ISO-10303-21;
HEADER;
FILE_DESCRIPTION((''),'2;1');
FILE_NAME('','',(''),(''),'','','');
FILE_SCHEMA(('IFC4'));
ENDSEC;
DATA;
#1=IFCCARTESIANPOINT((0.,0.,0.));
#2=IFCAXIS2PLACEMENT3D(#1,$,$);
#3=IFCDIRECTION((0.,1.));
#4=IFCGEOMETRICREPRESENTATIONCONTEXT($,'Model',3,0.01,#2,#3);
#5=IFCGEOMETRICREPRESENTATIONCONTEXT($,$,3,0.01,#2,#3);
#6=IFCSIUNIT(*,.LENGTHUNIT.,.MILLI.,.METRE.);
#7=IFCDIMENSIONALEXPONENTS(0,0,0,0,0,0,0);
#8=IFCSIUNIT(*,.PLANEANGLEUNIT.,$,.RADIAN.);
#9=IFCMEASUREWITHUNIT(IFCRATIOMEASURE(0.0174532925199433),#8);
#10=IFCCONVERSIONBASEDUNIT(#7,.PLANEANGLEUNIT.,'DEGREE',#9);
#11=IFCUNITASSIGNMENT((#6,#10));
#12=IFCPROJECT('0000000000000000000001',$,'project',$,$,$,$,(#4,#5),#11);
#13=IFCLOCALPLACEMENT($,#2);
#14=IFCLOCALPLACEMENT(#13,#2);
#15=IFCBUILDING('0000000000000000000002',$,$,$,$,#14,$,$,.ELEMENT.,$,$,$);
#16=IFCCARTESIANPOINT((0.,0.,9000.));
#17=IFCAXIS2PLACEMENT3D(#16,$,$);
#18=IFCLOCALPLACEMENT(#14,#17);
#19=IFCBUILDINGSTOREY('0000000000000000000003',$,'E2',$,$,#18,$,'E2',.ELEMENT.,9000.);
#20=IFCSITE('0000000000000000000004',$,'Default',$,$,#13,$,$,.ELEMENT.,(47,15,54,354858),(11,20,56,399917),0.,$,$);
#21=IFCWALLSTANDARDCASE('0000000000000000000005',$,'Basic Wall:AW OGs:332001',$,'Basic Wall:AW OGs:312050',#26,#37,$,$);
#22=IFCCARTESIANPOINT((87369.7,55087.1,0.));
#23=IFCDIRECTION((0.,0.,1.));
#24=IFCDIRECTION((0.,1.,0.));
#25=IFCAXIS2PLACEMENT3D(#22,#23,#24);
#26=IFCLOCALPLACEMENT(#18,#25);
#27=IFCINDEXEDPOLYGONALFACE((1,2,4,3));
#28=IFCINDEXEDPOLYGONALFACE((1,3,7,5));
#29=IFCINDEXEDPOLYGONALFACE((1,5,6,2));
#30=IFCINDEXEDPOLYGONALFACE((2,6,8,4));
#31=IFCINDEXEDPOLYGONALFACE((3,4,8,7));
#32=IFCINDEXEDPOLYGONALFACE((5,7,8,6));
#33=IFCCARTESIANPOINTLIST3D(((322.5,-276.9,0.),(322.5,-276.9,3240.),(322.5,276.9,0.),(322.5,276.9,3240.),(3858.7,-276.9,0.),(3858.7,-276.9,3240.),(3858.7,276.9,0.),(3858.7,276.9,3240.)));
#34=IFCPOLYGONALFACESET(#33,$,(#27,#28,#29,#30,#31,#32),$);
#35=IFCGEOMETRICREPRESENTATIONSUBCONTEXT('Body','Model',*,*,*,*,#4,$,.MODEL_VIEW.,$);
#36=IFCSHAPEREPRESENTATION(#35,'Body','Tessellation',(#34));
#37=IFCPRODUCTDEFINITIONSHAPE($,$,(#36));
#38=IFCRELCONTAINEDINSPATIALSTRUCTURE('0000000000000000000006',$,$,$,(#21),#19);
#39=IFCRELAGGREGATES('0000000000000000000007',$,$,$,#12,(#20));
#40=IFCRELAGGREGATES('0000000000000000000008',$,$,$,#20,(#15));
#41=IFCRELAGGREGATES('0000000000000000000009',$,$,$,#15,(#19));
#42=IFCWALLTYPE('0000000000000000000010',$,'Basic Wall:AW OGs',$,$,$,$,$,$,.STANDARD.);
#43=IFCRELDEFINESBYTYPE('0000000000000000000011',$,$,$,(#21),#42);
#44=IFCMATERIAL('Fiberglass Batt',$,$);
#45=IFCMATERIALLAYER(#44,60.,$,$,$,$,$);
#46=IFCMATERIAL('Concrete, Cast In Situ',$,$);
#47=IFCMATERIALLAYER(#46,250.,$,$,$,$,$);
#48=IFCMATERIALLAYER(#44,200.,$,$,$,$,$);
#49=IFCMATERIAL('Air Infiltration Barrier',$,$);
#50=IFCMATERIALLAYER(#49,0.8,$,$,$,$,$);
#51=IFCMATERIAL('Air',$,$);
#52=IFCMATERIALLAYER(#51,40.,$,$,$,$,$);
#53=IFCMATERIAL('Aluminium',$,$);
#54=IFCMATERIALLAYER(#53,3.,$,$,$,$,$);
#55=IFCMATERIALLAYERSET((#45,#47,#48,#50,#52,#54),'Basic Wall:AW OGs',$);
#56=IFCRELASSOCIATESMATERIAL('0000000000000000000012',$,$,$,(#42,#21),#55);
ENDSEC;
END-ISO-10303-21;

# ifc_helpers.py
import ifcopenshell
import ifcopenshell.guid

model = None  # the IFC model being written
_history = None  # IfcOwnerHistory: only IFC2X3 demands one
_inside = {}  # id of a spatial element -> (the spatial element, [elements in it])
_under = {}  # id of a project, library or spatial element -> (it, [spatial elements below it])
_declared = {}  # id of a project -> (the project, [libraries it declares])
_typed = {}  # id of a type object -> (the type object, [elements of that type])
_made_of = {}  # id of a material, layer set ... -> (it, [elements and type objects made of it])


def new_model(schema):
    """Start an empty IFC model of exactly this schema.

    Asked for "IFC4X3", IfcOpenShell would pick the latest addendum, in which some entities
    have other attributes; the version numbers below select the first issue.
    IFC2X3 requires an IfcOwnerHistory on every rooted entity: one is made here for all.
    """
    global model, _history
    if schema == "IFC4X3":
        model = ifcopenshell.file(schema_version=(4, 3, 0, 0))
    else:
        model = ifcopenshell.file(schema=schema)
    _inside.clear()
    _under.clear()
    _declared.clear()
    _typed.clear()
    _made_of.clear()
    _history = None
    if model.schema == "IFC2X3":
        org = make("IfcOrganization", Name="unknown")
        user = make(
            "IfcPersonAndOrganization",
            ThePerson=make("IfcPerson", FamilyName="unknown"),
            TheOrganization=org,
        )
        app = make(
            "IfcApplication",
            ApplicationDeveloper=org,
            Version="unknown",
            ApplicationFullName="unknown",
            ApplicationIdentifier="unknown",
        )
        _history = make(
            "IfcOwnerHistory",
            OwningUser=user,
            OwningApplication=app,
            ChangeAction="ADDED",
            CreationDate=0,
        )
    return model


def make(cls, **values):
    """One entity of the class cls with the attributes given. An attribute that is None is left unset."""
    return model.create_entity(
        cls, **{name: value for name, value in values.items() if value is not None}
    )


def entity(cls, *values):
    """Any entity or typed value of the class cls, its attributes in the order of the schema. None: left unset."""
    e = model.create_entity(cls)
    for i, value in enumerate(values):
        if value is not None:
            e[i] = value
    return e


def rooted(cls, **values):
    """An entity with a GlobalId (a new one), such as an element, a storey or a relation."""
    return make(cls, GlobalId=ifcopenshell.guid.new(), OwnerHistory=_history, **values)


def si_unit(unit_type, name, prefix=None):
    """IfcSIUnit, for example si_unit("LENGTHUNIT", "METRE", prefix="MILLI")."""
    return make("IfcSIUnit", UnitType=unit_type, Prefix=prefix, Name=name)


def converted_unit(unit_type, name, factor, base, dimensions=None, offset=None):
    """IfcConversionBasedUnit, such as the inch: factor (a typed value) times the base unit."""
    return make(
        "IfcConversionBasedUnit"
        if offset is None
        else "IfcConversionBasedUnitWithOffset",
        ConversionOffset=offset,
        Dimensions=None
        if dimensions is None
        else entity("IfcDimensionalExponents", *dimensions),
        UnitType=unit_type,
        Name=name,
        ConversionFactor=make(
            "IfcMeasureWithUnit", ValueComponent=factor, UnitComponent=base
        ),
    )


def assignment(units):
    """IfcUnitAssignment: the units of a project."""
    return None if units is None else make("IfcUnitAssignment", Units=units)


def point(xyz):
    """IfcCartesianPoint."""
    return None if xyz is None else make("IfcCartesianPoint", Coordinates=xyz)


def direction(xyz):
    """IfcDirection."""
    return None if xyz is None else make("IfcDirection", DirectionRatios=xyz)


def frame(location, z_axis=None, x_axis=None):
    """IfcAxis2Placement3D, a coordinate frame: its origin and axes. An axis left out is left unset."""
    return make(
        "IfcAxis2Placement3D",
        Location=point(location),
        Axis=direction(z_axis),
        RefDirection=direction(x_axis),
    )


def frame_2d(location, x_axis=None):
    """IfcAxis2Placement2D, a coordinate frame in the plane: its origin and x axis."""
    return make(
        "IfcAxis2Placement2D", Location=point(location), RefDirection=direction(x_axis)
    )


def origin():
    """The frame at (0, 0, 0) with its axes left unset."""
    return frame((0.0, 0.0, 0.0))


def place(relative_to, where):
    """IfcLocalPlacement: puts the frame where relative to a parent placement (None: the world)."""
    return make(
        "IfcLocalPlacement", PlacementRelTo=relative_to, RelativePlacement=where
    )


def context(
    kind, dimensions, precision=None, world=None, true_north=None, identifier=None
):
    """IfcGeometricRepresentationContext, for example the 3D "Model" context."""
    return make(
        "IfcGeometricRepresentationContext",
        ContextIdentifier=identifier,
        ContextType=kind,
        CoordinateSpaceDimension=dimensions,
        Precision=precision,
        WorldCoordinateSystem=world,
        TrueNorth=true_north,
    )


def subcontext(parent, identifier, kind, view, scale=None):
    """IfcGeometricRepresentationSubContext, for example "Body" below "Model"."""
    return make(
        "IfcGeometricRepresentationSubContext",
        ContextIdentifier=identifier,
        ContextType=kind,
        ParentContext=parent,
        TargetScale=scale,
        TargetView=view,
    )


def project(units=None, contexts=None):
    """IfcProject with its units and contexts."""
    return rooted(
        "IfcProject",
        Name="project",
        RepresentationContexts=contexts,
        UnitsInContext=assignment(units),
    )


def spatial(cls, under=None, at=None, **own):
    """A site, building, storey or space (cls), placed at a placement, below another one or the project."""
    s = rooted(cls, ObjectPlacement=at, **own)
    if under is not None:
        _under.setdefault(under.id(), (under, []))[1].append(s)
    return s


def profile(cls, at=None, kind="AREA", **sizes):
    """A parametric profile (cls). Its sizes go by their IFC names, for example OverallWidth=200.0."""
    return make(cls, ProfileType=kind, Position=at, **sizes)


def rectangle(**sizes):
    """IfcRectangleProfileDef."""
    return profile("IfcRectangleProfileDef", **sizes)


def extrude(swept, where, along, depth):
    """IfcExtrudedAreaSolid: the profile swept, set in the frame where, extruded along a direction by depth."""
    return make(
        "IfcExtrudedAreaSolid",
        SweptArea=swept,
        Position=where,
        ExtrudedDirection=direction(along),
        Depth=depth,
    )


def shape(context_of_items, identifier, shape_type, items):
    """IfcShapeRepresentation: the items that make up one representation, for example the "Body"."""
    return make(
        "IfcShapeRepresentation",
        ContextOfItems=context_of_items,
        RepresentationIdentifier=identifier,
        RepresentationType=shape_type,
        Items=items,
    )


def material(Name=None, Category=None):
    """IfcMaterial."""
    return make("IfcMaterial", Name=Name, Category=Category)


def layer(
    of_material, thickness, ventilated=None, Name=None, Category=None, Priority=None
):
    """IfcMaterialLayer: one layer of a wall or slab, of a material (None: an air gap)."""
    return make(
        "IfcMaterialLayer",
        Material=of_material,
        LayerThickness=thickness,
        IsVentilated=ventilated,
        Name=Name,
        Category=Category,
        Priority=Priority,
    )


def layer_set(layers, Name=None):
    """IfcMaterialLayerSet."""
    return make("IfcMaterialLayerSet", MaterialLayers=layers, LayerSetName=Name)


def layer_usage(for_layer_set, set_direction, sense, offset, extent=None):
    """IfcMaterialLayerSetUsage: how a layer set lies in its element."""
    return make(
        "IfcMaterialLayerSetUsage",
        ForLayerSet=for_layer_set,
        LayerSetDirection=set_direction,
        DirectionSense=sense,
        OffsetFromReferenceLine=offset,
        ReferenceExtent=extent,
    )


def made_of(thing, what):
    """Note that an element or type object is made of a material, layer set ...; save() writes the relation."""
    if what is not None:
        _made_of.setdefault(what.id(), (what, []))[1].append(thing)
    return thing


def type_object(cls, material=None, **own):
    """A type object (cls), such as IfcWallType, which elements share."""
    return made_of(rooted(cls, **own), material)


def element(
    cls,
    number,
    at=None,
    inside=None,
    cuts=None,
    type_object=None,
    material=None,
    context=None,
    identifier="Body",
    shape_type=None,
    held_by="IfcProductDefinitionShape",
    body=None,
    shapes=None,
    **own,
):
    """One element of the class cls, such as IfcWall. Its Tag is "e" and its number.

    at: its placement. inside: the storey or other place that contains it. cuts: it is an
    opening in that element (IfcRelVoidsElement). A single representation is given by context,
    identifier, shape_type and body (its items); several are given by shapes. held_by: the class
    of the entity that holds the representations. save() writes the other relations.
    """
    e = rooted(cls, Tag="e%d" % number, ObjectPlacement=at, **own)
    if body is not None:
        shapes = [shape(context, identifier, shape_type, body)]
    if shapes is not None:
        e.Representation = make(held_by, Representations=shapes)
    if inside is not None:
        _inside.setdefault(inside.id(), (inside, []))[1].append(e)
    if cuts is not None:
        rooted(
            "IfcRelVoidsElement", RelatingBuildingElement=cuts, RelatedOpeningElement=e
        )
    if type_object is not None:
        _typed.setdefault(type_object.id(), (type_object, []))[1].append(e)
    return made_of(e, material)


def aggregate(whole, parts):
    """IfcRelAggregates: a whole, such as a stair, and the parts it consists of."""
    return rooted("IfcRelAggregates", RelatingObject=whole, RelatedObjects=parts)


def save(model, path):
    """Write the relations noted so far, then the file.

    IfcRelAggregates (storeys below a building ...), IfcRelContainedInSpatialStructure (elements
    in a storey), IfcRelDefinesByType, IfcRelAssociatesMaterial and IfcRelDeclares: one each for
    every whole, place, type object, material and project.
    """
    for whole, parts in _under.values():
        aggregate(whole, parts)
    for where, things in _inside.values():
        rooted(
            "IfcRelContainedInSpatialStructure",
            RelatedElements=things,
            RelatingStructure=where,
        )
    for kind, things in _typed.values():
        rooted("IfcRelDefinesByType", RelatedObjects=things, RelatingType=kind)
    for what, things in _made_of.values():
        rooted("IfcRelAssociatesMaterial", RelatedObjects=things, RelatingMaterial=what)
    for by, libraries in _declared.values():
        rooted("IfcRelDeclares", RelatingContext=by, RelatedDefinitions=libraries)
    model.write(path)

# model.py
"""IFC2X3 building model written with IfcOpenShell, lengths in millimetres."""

from ifc_helpers import new_model, entity, si_unit, converted_unit, direction, frame, frame_2d, origin, place, context, subcontext, project, spatial, rectangle, extrude, material, layer, layer_set, layer_usage, type_object, element, save


model = new_model("IFC2X3")

# Units and contexts
model_context = context("Model", 3, precision=0.01, world=origin(), true_north=direction((0.0, 1.0)))
context_of_model = context(None, 3, precision=0.01, world=origin(), true_north=direction((0.0, 1.0)))
body_context = subcontext(model_context, "Body", "Model", "MODEL_VIEW")
ifc_project = project(units=[si_unit("LENGTHUNIT", "METRE", prefix="MILLI"), converted_unit("PLANEANGLEUNIT", "DEGREE", entity("IfcRatioMeasure", 0.0174532925199433), si_unit("PLANEANGLEUNIT", "RADIAN"), dimensions=[0, 0, 0, 0, 0, 0, 0])], contexts=[model_context, context_of_model])

# Site, building, storey
site_placement = place(None, origin())
site = spatial("IfcSite", under=ifc_project, at=site_placement, Name="Default", CompositionType="ELEMENT", RefLatitude=(47, 15, 54, 354858), RefLongitude=(11, 20, 56, 399917), RefElevation=0.0)
building_placement = place(site_placement, origin())
building = spatial("IfcBuilding", under=site, at=building_placement, CompositionType="ELEMENT")
storey_placement = place(building_placement, frame((0.0, 0.0, 9000.0)))
storey = spatial("IfcBuildingStorey", under=building, at=storey_placement, Name="E2", LongName="E2", CompositionType="ELEMENT", Elevation=9000.0)

# Shared definitions
ifc_material_1 = material(Name="Concrete, Cast In Situ")

# Shared definitions
ifc_material_2 = material(Name="Fiberglass Batt")
ifc_layer_1 = layer(ifc_material_2, 60.0)
ifc_layer_2 = layer(ifc_material_1, 250.0)
ifc_layer_3 = layer(ifc_material_2, 200.0)
ifc_material_3 = material(Name="Air Infiltration Barrier")
ifc_layer_4 = layer(ifc_material_3, 0.8)
ifc_material_4 = material(Name="Air")
ifc_layer_5 = layer(ifc_material_4, 40.0)
ifc_material_5 = material(Name="Aluminium")
ifc_layer_6 = layer(ifc_material_5, 3.0)
ifc_layer_set_1 = layer_set([ifc_layer_1, ifc_layer_2, ifc_layer_3, ifc_layer_4, ifc_layer_5, ifc_layer_6], Name="Basic Wall:AW OGs")
wall_type_1 = type_object("IfcWallType", Name="Basic Wall:AW OGs", PredefinedType="STANDARD", material=ifc_layer_set_1)

# Wall
ifc_layer_usage_1 = layer_usage(ifc_layer_set_1, "AXIS2", "NEGATIVE", 276.9)
wall_1_placement = place(storey_placement, frame((87369.7, 55087.1, 0.0), z_axis=(0.0, 0.0, 1.0), x_axis=(0.0, 1.0, 0.0)))
element("IfcWallStandardCase", 1, at=wall_1_placement, inside=storey, type_object=wall_type_1, material=ifc_layer_usage_1, Name="Basic Wall:AW OGs:332001", ObjectType="Basic Wall:AW OGs:312050", context=body_context, shape_type="SweptSolid", body=[
    extrude(rectangle(XDim=3536.2, YDim=553.8, at=frame_2d((2090.6, 0.0), x_axis=(-1.0, 0.0))), origin(), (0.0, 0.0, 1.0), 3240.0),
])

save(model, "model.ifc")
